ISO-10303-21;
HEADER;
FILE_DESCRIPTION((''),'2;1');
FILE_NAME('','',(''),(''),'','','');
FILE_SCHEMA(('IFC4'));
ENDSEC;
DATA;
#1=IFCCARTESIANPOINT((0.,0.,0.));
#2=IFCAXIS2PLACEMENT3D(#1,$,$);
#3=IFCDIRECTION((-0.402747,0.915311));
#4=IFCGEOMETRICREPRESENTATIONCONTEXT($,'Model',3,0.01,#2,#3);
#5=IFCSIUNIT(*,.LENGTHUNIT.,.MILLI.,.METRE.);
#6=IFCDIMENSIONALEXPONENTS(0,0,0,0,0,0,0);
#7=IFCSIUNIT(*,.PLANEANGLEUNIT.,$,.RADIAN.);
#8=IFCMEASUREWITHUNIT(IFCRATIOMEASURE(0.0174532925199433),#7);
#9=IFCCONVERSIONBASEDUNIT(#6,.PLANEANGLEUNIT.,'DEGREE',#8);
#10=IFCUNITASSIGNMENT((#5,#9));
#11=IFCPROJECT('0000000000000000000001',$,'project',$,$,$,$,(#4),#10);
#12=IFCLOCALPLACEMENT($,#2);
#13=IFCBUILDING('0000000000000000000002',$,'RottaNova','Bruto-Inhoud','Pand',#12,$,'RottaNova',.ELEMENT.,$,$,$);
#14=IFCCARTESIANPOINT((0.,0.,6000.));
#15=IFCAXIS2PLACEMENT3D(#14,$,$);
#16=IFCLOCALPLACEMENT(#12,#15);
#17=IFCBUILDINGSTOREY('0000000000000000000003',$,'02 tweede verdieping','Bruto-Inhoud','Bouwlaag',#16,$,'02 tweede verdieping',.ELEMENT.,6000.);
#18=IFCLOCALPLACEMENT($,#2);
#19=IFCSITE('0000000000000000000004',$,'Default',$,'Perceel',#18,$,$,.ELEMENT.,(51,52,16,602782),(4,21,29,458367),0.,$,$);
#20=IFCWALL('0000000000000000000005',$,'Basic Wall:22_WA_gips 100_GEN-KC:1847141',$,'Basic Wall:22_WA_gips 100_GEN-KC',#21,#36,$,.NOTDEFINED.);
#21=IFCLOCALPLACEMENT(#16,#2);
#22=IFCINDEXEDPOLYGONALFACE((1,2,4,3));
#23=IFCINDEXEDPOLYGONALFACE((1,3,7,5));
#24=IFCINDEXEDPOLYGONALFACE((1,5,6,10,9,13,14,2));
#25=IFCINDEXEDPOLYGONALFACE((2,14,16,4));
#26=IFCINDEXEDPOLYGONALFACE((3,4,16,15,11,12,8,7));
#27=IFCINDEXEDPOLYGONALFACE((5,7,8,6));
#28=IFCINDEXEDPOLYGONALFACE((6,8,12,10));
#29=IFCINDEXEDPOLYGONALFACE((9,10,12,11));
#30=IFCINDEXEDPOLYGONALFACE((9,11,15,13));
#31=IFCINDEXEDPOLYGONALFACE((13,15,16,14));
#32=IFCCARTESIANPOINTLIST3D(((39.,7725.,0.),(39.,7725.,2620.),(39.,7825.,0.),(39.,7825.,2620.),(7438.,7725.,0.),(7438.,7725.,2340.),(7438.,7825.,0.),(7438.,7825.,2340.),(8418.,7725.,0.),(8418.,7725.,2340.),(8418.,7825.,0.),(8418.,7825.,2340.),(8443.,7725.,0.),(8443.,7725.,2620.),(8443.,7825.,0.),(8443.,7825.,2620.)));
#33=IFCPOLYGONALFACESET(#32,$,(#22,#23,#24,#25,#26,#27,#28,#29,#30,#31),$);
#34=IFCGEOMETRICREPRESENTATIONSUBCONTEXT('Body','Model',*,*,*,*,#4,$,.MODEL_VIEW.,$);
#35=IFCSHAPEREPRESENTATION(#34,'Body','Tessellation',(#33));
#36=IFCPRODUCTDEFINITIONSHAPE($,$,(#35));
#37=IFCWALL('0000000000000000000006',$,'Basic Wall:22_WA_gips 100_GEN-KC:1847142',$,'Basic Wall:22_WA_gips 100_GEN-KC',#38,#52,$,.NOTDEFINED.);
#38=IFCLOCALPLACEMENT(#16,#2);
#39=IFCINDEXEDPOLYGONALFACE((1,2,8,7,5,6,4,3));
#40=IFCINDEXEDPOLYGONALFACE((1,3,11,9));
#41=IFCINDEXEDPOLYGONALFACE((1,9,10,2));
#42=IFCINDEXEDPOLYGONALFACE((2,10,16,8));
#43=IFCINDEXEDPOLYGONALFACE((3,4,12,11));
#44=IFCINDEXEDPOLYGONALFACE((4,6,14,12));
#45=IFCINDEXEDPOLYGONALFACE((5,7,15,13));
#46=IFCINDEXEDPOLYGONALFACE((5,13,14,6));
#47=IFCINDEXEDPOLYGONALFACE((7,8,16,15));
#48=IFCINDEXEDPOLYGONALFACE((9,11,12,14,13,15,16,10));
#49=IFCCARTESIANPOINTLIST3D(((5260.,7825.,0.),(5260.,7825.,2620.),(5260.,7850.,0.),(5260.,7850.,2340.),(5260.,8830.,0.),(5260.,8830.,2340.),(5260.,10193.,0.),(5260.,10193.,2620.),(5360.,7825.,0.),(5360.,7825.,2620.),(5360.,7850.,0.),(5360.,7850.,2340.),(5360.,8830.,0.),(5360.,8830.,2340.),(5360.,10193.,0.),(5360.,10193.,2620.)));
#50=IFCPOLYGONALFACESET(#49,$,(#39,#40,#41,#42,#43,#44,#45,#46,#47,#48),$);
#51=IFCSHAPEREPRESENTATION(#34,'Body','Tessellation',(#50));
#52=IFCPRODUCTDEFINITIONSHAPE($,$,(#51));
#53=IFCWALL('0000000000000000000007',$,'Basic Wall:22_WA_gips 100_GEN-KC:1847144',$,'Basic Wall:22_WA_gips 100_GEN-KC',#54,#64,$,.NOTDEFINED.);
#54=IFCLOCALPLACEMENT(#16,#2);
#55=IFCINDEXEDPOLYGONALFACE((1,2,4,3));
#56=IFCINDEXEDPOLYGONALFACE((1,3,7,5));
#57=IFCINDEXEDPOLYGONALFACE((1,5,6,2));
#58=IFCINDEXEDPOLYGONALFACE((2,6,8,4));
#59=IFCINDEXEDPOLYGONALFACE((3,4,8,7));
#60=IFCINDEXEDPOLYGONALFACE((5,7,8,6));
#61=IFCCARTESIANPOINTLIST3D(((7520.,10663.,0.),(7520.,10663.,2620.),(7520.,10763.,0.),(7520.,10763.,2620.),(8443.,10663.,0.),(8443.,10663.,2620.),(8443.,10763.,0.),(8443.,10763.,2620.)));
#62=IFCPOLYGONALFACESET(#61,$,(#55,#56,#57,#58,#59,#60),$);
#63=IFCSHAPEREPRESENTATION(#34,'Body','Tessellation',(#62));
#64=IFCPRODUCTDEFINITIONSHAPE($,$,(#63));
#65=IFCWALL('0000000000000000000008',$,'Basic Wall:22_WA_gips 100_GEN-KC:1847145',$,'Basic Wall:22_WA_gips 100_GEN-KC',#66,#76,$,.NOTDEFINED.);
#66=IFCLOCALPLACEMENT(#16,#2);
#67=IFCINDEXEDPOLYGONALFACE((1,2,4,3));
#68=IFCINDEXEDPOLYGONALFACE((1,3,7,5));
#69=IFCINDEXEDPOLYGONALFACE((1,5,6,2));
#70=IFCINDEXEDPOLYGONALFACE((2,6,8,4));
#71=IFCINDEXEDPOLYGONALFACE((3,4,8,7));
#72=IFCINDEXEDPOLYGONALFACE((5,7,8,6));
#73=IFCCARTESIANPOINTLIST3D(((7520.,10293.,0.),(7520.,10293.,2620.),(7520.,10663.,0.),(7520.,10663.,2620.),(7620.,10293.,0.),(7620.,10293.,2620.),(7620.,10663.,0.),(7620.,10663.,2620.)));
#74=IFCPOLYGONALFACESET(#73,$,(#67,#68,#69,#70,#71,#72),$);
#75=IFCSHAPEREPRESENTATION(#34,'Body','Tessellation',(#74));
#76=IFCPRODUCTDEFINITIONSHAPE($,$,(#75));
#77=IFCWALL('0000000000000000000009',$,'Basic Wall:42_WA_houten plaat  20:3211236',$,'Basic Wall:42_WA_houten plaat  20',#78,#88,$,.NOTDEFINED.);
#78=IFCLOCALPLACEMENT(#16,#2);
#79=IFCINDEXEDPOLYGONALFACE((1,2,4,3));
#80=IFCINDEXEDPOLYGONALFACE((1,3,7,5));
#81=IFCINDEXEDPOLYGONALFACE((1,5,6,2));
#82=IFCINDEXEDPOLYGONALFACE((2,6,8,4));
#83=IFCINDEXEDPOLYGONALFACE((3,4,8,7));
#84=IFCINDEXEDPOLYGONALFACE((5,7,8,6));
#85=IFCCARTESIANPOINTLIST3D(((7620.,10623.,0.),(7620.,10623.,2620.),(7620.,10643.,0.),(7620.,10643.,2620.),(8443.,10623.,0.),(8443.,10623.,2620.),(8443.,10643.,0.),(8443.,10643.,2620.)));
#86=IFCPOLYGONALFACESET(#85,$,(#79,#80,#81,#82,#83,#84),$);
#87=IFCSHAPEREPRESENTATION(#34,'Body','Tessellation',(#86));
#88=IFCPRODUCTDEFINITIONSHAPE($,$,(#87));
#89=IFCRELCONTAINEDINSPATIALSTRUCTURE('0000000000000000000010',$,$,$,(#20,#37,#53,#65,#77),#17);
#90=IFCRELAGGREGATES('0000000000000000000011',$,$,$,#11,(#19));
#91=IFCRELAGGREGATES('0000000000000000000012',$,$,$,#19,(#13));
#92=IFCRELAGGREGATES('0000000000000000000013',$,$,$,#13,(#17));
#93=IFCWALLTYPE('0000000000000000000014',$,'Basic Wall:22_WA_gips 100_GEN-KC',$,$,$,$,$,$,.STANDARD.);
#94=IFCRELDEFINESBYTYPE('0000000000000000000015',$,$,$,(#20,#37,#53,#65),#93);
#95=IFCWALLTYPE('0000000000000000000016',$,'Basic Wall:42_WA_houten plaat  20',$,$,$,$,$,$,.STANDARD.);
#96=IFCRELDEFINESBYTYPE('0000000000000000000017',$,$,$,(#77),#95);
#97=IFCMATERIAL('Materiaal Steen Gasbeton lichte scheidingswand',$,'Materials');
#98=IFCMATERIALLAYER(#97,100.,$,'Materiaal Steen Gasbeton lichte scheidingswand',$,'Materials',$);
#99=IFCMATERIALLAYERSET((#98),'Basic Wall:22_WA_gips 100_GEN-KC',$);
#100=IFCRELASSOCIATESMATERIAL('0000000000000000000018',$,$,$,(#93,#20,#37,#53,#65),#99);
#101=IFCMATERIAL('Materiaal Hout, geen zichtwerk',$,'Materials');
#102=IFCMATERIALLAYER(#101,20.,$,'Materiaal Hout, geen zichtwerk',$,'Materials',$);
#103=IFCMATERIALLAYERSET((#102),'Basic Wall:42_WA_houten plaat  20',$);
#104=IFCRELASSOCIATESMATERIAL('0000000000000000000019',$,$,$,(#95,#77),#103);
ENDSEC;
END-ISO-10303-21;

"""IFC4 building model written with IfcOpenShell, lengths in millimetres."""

from ifc_helpers import new_model, entity, si_unit, converted_unit, direction, frame, frame_2d, origin, place, context, subcontext, project, spatial, rectangle, extrude, material, layer, layer_set, type_object, element, save


model = new_model("IFC4")

# Units and contexts
model_context = context("Model", 3, precision=0.01, world=origin(), true_north=direction((-0.402747, 0.915311)))
body_context = subcontext(model_context, "Body", "Model", "MODEL_VIEW")
ifc_project = project(units=[si_unit("LENGTHUNIT", "METRE", prefix="MILLI"), converted_unit("PLANEANGLEUNIT", "DEGREE", entity("IfcRatioMeasure", 0.0174532925199433), si_unit("PLANEANGLEUNIT", "RADIAN"), dimensions=[0, 0, 0, 0, 0, 0, 0])], contexts=[model_context])

# Site, building, storey
site_placement = place(None, origin())
site = spatial("IfcSite", under=ifc_project, at=site_placement, Name="Default", ObjectType="Perceel", CompositionType="ELEMENT", RefLatitude=(51, 52, 16, 602782), RefLongitude=(4, 21, 29, 458367), RefElevation=0.0)
building_placement = place(None, origin())
building = spatial("IfcBuilding", under=site, at=building_placement, Name="RottaNova", Description="Bruto-Inhoud", ObjectType="Pand", LongName="RottaNova", CompositionType="ELEMENT")
storey_placement = place(building_placement, frame((0.0, 0.0, 6000.0)))
storey = spatial("IfcBuildingStorey", under=building, at=storey_placement, Name="02 tweede verdieping", Description="Bruto-Inhoud", ObjectType="Bouwlaag", LongName="02 tweede verdieping", CompositionType="ELEMENT", Elevation=6000.0)

# Walls, openings
ifc_material_1 = material(Name="Materiaal Steen Gasbeton lichte scheidingswand", Category="Materials")
ifc_layer_1 = layer(ifc_material_1, 100.0, Name="Materiaal Steen Gasbeton lichte scheidingswand", Category="Materials")
ifc_layer_set_1 = layer_set([ifc_layer_1], Name="Basic Wall:22_WA_gips 100_GEN-KC")
wall_type_1 = type_object("IfcWallType", Name="Basic Wall:22_WA_gips 100_GEN-KC", PredefinedType="STANDARD", material=ifc_layer_set_1)
wall_1_placement = place(storey_placement, frame((39.0, 7775.0, 0.0)))
wall_1 = element("IfcWall", 1, at=wall_1_placement, inside=storey, type_object=wall_type_1, material=ifc_layer_set_1, Name="Basic Wall:22_WA_gips 100_GEN-KC:1847141", ObjectType="Basic Wall:22_WA_gips 100_GEN-KC", PredefinedType="NOTDEFINED", context=body_context, shape_type="SweptSolid", body=[
    extrude(rectangle(XDim=8404.0, YDim=100.0, at=frame_2d((4202.0, 0.0), x_axis=(1.0, 0.0))), origin(), (0.0, 0.0, 1.0), 2620.0),
])
opening_1_placement = place(wall_1_placement, frame((8379.0, 50.0, -90.0)))
element("IfcOpeningElement", 2, at=opening_1_placement, cuts=wall_1, PredefinedType="OPENING", context=body_context, shape_type="SweptSolid", body=[
    extrude(rectangle(XDim=2430.0, YDim=980.0, at=frame_2d((1215.0, 490.0), x_axis=(1.0, 0.0))), frame((0.0, 0.0, 0.0), z_axis=(0.0, -1.0, 0.0), x_axis=(0.0, 0.0, 1.0)), (0.0, 0.0, 1.0), 100.0),
])
wall_2_placement = place(storey_placement, frame((5310.0, 10193.0, 0.0), z_axis=(0.0, 0.0, 1.0), x_axis=(0.0, -1.0, 0.0)))
wall_2 = element("IfcWall", 3, at=wall_2_placement, inside=storey, type_object=wall_type_1, material=ifc_layer_set_1, Name="Basic Wall:22_WA_gips 100_GEN-KC:1847142", ObjectType="Basic Wall:22_WA_gips 100_GEN-KC", PredefinedType="NOTDEFINED", context=body_context, shape_type="SweptSolid", body=[
    extrude(rectangle(XDim=2368.0, YDim=100.0, at=frame_2d((1184.0, 0.0), x_axis=(1.0, 0.0))), origin(), (0.0, 0.0, 1.0), 2620.0),
])
opening_2_placement = place(wall_2_placement, frame((2343.0, 50.0, -90.0)))
element("IfcOpeningElement", 4, at=opening_2_placement, cuts=wall_2, PredefinedType="OPENING", context=body_context, shape_type="SweptSolid", body=[
    extrude(rectangle(XDim=2430.0, YDim=980.0, at=frame_2d((1215.0, 490.0), x_axis=(1.0, 0.0))), frame((0.0, 0.0, 0.0), z_axis=(0.0, -1.0, 0.0), x_axis=(0.0, 0.0, 1.0)), (0.0, 0.0, 1.0), 100.0),
])

# Walls
wall_3_placement = place(storey_placement, frame((7520.0, 10713.0, 0.0)))
element("IfcWall", 5, at=wall_3_placement, inside=storey, type_object=wall_type_1, material=ifc_layer_set_1, Name="Basic Wall:22_WA_gips 100_GEN-KC:1847144", ObjectType="Basic Wall:22_WA_gips 100_GEN-KC", PredefinedType="NOTDEFINED", context=body_context, shape_type="SweptSolid", body=[
    extrude(rectangle(XDim=923.0, YDim=100.0, at=frame_2d((461.5, 0.0), x_axis=(-1.0, 0.0))), origin(), (0.0, 0.0, 1.0), 2620.0),
])
wall_4_placement = place(storey_placement, frame((7570.0, 10663.0, 0.0), z_axis=(0.0, 0.0, 1.0), x_axis=(0.0, -1.0, 0.0)))
element("IfcWall", 6, at=wall_4_placement, inside=storey, type_object=wall_type_1, material=ifc_layer_set_1, Name="Basic Wall:22_WA_gips 100_GEN-KC:1847145", ObjectType="Basic Wall:22_WA_gips 100_GEN-KC", PredefinedType="NOTDEFINED", context=body_context, shape_type="SweptSolid", body=[
    extrude(rectangle(XDim=370.0, YDim=100.0, at=frame_2d((185.0, 0.0), x_axis=(-1.0, 0.0))), origin(), (0.0, 0.0, 1.0), 2620.0),
])
ifc_material_2 = material(Name="Materiaal Hout, geen zichtwerk", Category="Materials")
ifc_layer_2 = layer(ifc_material_2, 20.0, Name="Materiaal Hout, geen zichtwerk", Category="Materials")
ifc_layer_set_2 = layer_set([ifc_layer_2], Name="Basic Wall:42_WA_houten plaat  20")
wall_type_2 = type_object("IfcWallType", Name="Basic Wall:42_WA_houten plaat  20", PredefinedType="STANDARD", material=ifc_layer_set_2)
wall_5_placement = place(storey_placement, frame((7620.0, 10633.0, 0.0)))
element("IfcWall", 7, at=wall_5_placement, inside=storey, type_object=wall_type_2, material=ifc_layer_set_2, Name="Basic Wall:42_WA_houten plaat  20:3211236", ObjectType="Basic Wall:42_WA_houten plaat  20", PredefinedType="NOTDEFINED", context=body_context, shape_type="SweptSolid", body=[
    extrude(rectangle(XDim=823.0, YDim=20.0, at=frame_2d((411.5, 0.0), x_axis=(-1.0, 0.0))), origin(), (0.0, 0.0, 1.0), 2620.0),
])

save(model, "model.ifc")
